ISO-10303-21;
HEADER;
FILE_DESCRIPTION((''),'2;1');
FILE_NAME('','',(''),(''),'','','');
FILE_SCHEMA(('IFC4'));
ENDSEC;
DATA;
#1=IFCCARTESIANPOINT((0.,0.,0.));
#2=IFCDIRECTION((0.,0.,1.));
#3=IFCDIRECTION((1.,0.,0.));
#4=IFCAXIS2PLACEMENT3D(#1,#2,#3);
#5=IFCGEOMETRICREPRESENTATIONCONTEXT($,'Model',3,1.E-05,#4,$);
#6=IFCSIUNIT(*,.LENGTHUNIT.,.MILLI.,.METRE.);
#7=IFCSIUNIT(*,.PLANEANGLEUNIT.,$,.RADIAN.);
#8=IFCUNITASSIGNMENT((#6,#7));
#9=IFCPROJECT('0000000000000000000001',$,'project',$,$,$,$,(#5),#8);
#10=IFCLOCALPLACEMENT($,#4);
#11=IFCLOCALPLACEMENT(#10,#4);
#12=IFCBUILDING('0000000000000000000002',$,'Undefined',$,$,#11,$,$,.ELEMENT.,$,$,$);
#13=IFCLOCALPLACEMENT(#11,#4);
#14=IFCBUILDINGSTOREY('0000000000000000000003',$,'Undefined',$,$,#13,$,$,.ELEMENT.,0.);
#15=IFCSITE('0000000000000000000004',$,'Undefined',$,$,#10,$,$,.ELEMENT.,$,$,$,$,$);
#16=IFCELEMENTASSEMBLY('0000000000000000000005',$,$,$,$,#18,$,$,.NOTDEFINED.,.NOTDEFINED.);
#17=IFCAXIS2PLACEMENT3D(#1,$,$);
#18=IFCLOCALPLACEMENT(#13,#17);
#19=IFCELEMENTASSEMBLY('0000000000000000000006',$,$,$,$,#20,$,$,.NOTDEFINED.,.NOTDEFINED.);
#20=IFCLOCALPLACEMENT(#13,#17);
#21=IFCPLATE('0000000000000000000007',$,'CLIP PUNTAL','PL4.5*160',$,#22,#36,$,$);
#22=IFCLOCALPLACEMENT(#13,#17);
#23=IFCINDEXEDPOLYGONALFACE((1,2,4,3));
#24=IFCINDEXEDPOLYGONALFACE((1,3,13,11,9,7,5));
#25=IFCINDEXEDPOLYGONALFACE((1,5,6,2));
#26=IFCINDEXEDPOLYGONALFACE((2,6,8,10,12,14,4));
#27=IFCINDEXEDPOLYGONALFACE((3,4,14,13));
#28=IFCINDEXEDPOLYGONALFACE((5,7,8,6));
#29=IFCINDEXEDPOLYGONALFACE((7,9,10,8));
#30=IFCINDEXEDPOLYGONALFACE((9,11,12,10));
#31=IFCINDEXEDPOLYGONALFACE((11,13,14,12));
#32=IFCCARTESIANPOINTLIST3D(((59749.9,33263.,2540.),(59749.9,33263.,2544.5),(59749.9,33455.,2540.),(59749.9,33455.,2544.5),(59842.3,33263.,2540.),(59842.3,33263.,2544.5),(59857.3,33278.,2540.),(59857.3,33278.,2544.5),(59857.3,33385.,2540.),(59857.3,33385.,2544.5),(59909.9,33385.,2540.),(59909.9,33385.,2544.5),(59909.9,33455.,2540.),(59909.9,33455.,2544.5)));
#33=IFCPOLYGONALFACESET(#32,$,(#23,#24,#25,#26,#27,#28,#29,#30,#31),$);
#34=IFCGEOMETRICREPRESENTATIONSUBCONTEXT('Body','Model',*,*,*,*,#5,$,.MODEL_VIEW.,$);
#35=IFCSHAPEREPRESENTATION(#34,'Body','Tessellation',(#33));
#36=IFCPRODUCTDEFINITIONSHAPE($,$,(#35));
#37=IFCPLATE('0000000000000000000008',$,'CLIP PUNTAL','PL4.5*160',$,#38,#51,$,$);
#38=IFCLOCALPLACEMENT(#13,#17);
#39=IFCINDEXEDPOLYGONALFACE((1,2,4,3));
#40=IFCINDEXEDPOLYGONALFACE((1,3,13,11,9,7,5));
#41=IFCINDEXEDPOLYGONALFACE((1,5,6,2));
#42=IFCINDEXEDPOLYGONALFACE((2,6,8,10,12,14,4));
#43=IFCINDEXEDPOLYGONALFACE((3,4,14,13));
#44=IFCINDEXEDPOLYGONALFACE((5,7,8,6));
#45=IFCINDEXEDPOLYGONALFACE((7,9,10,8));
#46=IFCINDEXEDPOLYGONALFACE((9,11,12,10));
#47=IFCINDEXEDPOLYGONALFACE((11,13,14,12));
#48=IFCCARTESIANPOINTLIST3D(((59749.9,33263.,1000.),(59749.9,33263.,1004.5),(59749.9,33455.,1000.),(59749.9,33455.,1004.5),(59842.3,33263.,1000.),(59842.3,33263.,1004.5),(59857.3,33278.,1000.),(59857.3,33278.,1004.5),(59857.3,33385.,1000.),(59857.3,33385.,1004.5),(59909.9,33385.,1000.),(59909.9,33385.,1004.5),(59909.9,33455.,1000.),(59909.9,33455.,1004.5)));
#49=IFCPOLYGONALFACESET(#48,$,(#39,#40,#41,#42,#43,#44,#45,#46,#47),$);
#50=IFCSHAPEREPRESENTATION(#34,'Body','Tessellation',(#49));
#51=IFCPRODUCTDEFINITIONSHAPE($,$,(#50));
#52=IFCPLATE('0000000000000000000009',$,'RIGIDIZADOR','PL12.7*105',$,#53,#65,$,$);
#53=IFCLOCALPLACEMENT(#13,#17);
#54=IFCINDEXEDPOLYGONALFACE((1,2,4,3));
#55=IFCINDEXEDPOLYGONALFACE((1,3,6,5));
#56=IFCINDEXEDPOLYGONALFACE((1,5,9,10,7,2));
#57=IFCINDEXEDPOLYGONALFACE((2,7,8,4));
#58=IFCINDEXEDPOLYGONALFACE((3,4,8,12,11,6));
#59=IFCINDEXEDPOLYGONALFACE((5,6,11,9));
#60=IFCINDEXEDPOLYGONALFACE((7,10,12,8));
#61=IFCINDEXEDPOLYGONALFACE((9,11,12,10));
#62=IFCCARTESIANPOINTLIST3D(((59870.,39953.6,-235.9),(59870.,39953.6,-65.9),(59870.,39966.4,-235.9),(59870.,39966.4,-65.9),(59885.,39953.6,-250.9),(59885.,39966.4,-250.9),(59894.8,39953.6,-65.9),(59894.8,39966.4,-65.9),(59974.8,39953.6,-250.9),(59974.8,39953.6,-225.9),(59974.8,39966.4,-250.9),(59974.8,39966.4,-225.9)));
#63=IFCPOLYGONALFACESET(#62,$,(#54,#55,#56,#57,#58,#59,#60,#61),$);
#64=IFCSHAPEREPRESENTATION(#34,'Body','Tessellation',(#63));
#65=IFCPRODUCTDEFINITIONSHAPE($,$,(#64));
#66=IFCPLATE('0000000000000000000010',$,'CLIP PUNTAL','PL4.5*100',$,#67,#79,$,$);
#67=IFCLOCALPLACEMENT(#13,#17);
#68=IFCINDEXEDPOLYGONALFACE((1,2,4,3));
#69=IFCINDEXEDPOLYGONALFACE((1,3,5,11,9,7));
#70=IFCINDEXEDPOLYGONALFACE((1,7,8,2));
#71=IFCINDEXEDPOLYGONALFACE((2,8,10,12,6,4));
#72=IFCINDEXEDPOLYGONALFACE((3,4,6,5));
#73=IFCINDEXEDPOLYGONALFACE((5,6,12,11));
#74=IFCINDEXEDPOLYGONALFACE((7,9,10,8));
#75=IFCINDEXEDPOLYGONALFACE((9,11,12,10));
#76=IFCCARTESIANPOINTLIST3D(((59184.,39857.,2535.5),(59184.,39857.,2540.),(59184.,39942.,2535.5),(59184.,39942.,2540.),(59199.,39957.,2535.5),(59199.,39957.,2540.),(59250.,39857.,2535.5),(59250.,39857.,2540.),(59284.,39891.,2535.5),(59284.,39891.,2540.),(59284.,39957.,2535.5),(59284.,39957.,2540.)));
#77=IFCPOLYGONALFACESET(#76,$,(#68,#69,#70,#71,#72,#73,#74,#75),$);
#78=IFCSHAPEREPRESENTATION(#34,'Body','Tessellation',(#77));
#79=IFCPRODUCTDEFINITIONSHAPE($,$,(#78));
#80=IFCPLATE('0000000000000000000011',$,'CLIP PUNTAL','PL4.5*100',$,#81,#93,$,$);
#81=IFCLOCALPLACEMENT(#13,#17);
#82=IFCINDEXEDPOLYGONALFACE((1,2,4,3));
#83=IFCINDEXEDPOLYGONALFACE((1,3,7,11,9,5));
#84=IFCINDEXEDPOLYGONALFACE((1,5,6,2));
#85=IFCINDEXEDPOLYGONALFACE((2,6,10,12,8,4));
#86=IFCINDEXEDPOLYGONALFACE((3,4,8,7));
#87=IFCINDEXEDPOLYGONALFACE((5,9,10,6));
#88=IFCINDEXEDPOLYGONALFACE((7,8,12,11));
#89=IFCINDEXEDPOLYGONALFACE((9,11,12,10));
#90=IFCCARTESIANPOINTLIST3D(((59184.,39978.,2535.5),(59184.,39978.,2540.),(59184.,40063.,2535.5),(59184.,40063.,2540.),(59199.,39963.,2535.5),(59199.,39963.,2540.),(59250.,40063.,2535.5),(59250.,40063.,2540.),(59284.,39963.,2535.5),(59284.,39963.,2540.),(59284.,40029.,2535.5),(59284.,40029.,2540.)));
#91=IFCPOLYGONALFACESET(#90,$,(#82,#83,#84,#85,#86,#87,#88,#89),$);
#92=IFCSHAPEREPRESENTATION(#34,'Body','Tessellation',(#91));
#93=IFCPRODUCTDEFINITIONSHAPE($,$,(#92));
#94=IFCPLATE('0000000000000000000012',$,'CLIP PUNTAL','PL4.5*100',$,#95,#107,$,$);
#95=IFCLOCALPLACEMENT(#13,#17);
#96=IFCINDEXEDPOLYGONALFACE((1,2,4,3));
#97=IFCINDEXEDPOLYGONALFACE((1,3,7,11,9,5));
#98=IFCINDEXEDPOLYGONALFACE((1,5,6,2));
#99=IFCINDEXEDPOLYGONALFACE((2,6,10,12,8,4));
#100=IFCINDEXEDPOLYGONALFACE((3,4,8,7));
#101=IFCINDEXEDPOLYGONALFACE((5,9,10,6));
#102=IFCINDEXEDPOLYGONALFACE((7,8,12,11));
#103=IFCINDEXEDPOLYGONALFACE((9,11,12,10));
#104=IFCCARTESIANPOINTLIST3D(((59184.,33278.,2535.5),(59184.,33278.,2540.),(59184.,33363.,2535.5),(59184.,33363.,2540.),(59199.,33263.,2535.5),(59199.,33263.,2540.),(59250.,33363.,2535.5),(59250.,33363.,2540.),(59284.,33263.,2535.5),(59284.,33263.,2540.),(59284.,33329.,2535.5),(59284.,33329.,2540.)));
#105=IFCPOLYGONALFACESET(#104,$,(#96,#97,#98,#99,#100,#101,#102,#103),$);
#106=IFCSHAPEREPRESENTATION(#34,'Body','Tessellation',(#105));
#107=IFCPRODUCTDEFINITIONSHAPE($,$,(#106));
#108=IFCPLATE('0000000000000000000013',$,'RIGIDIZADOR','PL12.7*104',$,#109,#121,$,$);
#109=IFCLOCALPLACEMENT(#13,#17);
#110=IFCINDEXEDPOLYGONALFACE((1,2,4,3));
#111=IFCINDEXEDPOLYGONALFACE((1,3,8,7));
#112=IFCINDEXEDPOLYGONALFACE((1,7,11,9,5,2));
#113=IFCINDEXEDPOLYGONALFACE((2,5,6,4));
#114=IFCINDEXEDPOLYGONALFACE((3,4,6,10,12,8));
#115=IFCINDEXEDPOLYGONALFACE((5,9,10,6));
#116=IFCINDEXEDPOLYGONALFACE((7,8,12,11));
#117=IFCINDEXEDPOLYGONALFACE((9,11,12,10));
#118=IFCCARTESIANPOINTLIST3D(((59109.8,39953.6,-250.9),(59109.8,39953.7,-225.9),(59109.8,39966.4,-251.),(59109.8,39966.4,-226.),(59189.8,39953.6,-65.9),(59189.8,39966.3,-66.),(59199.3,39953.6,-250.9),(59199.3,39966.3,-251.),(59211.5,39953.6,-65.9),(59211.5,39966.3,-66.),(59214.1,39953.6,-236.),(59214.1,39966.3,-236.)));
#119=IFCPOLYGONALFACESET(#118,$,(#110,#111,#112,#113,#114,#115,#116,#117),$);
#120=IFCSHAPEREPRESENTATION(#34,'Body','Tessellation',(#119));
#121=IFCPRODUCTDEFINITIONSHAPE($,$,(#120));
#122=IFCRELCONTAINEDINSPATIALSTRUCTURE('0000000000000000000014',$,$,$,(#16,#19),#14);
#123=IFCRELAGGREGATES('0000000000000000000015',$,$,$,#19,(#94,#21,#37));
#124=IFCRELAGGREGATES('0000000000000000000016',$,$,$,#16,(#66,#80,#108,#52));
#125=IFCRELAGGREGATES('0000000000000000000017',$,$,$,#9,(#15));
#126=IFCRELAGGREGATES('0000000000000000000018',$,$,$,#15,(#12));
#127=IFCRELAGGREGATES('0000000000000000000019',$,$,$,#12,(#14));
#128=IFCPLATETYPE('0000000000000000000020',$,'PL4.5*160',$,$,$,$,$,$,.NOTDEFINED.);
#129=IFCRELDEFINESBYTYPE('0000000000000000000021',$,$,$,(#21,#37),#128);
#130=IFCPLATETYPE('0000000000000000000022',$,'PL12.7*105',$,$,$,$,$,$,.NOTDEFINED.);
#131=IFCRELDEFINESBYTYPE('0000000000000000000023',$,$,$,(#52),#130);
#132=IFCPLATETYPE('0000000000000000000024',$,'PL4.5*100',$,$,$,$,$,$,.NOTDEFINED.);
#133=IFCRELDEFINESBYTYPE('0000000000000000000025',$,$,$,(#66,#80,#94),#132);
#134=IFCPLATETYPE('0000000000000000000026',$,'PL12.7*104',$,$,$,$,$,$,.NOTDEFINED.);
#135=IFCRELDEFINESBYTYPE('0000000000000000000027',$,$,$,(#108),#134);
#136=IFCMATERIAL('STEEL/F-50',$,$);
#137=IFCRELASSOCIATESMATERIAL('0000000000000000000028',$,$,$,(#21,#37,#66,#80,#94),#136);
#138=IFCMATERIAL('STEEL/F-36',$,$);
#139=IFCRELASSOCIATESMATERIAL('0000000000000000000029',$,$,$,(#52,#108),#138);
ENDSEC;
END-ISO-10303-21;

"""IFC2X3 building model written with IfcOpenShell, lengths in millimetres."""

from ifc_helpers import new_model, si_unit, frame, origin_with_axes, place, context, subcontext, project, spatial, polyline, outline, extrude, material, type_object, element, aggregate, save


model = new_model("IFC2X3")

# Units and contexts
model_context = context("Model", 3, precision=1e-05, world=origin_with_axes())
body_context = subcontext(model_context, "Body", "Model", "MODEL_VIEW")
ifc_project = project(units=[si_unit("LENGTHUNIT", "METRE", prefix="MILLI"), si_unit("PLANEANGLEUNIT", "RADIAN")], contexts=[model_context])

# Site, building, storey
site_placement = place(None, origin_with_axes())
site = spatial("IfcSite", under=ifc_project, at=site_placement, Name="Undefined", CompositionType="ELEMENT")
building_placement = place(site_placement, origin_with_axes())
building = spatial("IfcBuilding", under=site, at=building_placement, Name="Undefined", CompositionType="ELEMENT")
storey_placement = place(building_placement, origin_with_axes())
storey = spatial("IfcBuildingStorey", under=building, at=storey_placement, Name="Undefined", CompositionType="ELEMENT", Elevation=0.0)

# Element assembly
assembly_1_placement = place(storey_placement, origin_with_axes())
assembly_1 = element("IfcElementAssembly", 1, at=assembly_1_placement, inside=storey, AssemblyPlace="NOTDEFINED", PredefinedType="NOTDEFINED")
ifc_material_1 = material(Name="STEEL/F-36")
ifc_material_2 = material(Name="STEEL/F-50")
plate_type_1 = type_object("IfcPlateType", Name="PL4.5*160", PredefinedType="NOTDEFINED")

# Element assembly, plates
assembly_2_placement = place(storey_placement, origin_with_axes())
assembly_2 = element("IfcElementAssembly", 2, at=assembly_2_placement, inside=storey, AssemblyPlace="NOTDEFINED", PredefinedType="NOTDEFINED")
plate_1_placement = place(assembly_2_placement, frame((59857.3, 33263.0, 2542.2), z_axis=(0.0, 0.0, 1.0), x_axis=(0.0, 1.0, 0.0)))
plate_1 = element("IfcPlate", 3, at=plate_1_placement, type_object=plate_type_1, material=ifc_material_2, Name="CLIP PUNTAL", Description="PL4.5*160", context=body_context, shape_type="SweptSolid", body=[
    extrude(outline(polyline([(0.0, 15.0), (15.0, 0.0), (122.0, 0.0), (122.0, -52.6), (192.0, -52.6), (192.0, 107.4), (0.0, 107.4), (0.0, 15.0)])), frame((0.0, 0.0, -2.2), z_axis=(0.0, 0.0, 1.0), x_axis=(1.0, 0.0, 0.0)), (0.0, 0.0, 1.0), 4.5),
])
plate_2_placement = place(assembly_2_placement, frame((59857.3, 33263.0, 1002.2), z_axis=(0.0, 0.0, 1.0), x_axis=(0.0, 1.0, 0.0)))
plate_2 = element("IfcPlate", 4, at=plate_2_placement, type_object=plate_type_1, material=ifc_material_2, Name="CLIP PUNTAL", Description="PL4.5*160", context=body_context, shape_type="SweptSolid", body=[
    extrude(outline(polyline([(0.0, 15.0), (15.0, 0.0), (122.0, 0.0), (122.0, -52.6), (192.0, -52.6), (192.0, 107.4), (0.0, 107.4), (0.0, 15.0)])), frame((0.0, 0.0, -2.2), z_axis=(0.0, 0.0, 1.0), x_axis=(1.0, 0.0, 0.0)), (0.0, 0.0, 1.0), 4.5),
])

# Plates
plate_type_2 = type_object("IfcPlateType", Name="PL12.7*105", PredefinedType="NOTDEFINED")
plate_3_placement = place(assembly_1_placement, frame((59974.8, 39960.0, -250.9), z_axis=(0.0, 1.0, 0.0), x_axis=(-1.0, 0.0, 0.0)))
plate_3 = element("IfcPlate", 5, at=plate_3_placement, type_object=plate_type_2, material=ifc_material_1, Name="RIGIDIZADOR", Description="PL12.7*105", context=body_context, shape_type="SweptSolid", body=[
    extrude(outline(polyline([(0.0, 0.0), (89.8, 0.0), (104.8, 15.0), (104.8, 185.0), (80.0, 185.0), (0.0, 25.0), (0.0, 0.0)])), frame((0.0, 0.0, -6.4), z_axis=(0.0, 0.0, 1.0), x_axis=(1.0, 0.0, 0.0)), (0.0, 0.0, 1.0), 12.7),
])
plate_type_3 = type_object("IfcPlateType", Name="PL4.5*100", PredefinedType="NOTDEFINED")
plate_4_placement = place(assembly_1_placement, frame((59284.0, 39957.0, 2537.7), z_axis=(0.0, 0.0, -1.0), x_axis=(0.0, -1.0, 0.0)))
plate_4 = element("IfcPlate", 6, at=plate_4_placement, type_object=plate_type_3, material=ifc_material_2, Name="CLIP PUNTAL", Description="PL4.5*100", context=body_context, shape_type="SweptSolid", body=[
    extrude(outline(polyline([(0.0, 0.0), (66.0, 0.0), (100.0, 34.0), (100.0, 100.0), (15.0, 100.0), (0.0, 85.0), (0.0, 0.0)])), frame((0.0, 0.0, -2.2), z_axis=(0.0, 0.0, 1.0), x_axis=(1.0, 0.0, 0.0)), (0.0, 0.0, 1.0), 4.5),
])
plate_5_placement = place(assembly_1_placement, frame((59284.0, 39963.0, 2537.7), z_axis=(0.0, 0.0, 1.0), x_axis=(0.0, 1.0, 0.0)))
plate_5 = element("IfcPlate", 7, at=plate_5_placement, type_object=plate_type_3, material=ifc_material_2, Name="CLIP PUNTAL", Description="PL4.5*100", context=body_context, shape_type="SweptSolid", body=[
    extrude(outline(polyline([(0.0, 0.0), (66.0, 0.0), (100.0, 34.0), (100.0, 100.0), (15.0, 100.0), (0.0, 85.0), (0.0, 0.0)])), frame((0.0, 0.0, -2.2), z_axis=(0.0, 0.0, 1.0), x_axis=(1.0, 0.0, 0.0)), (0.0, 0.0, 1.0), 4.5),
])
plate_6_placement = place(assembly_2_placement, frame((59284.0, 33263.0, 2537.7), z_axis=(0.0, 0.0, 1.0), x_axis=(0.0, 1.0, 0.0)))
plate_6 = element("IfcPlate", 8, at=plate_6_placement, type_object=plate_type_3, material=ifc_material_2, Name="CLIP PUNTAL", Description="PL4.5*100", context=body_context, shape_type="SweptSolid", body=[
    extrude(outline(polyline([(0.0, 0.0), (66.0, 0.0), (100.0, 34.0), (100.0, 100.0), (15.0, 100.0), (0.0, 85.0), (0.0, 0.0)])), frame((0.0, 0.0, -2.2), z_axis=(0.0, 0.0, 1.0), x_axis=(1.0, 0.0, 0.0)), (0.0, 0.0, 1.0), 4.5),
])
plate_type_4 = type_object("IfcPlateType", Name="PL12.7*104", PredefinedType="NOTDEFINED")
plate_7_placement = place(assembly_1_placement, frame((59109.8, 39960.0, -250.9), z_axis=(0.0, -1.0, 0.0), x_axis=(1.0, 0.0, 0.0)))
plate_7 = element("IfcPlate", 9, at=plate_7_placement, type_object=plate_type_4, material=ifc_material_1, Name="RIGIDIZADOR", Description="PL12.7*104", context=body_context, shape_type="SweptSolid", body=[
    extrude(outline(polyline([(0.0, 0.0), (89.5, 0.0), (104.3, 15.0), (101.7, 185.0), (80.0, 185.0), (0.0, 25.0), (0.0, 0.0)])), frame((0.0, 0.0, -6.4), z_axis=(0.0, 0.0, 1.0), x_axis=(1.0, 0.0, 0.0)), (0.0, 0.0, 1.0), 12.7),
])

aggregate(assembly_2, [plate_6, plate_1, plate_2])
aggregate(assembly_1, [plate_4, plate_5, plate_7, plate_3])

save(model, "model.ifc")
